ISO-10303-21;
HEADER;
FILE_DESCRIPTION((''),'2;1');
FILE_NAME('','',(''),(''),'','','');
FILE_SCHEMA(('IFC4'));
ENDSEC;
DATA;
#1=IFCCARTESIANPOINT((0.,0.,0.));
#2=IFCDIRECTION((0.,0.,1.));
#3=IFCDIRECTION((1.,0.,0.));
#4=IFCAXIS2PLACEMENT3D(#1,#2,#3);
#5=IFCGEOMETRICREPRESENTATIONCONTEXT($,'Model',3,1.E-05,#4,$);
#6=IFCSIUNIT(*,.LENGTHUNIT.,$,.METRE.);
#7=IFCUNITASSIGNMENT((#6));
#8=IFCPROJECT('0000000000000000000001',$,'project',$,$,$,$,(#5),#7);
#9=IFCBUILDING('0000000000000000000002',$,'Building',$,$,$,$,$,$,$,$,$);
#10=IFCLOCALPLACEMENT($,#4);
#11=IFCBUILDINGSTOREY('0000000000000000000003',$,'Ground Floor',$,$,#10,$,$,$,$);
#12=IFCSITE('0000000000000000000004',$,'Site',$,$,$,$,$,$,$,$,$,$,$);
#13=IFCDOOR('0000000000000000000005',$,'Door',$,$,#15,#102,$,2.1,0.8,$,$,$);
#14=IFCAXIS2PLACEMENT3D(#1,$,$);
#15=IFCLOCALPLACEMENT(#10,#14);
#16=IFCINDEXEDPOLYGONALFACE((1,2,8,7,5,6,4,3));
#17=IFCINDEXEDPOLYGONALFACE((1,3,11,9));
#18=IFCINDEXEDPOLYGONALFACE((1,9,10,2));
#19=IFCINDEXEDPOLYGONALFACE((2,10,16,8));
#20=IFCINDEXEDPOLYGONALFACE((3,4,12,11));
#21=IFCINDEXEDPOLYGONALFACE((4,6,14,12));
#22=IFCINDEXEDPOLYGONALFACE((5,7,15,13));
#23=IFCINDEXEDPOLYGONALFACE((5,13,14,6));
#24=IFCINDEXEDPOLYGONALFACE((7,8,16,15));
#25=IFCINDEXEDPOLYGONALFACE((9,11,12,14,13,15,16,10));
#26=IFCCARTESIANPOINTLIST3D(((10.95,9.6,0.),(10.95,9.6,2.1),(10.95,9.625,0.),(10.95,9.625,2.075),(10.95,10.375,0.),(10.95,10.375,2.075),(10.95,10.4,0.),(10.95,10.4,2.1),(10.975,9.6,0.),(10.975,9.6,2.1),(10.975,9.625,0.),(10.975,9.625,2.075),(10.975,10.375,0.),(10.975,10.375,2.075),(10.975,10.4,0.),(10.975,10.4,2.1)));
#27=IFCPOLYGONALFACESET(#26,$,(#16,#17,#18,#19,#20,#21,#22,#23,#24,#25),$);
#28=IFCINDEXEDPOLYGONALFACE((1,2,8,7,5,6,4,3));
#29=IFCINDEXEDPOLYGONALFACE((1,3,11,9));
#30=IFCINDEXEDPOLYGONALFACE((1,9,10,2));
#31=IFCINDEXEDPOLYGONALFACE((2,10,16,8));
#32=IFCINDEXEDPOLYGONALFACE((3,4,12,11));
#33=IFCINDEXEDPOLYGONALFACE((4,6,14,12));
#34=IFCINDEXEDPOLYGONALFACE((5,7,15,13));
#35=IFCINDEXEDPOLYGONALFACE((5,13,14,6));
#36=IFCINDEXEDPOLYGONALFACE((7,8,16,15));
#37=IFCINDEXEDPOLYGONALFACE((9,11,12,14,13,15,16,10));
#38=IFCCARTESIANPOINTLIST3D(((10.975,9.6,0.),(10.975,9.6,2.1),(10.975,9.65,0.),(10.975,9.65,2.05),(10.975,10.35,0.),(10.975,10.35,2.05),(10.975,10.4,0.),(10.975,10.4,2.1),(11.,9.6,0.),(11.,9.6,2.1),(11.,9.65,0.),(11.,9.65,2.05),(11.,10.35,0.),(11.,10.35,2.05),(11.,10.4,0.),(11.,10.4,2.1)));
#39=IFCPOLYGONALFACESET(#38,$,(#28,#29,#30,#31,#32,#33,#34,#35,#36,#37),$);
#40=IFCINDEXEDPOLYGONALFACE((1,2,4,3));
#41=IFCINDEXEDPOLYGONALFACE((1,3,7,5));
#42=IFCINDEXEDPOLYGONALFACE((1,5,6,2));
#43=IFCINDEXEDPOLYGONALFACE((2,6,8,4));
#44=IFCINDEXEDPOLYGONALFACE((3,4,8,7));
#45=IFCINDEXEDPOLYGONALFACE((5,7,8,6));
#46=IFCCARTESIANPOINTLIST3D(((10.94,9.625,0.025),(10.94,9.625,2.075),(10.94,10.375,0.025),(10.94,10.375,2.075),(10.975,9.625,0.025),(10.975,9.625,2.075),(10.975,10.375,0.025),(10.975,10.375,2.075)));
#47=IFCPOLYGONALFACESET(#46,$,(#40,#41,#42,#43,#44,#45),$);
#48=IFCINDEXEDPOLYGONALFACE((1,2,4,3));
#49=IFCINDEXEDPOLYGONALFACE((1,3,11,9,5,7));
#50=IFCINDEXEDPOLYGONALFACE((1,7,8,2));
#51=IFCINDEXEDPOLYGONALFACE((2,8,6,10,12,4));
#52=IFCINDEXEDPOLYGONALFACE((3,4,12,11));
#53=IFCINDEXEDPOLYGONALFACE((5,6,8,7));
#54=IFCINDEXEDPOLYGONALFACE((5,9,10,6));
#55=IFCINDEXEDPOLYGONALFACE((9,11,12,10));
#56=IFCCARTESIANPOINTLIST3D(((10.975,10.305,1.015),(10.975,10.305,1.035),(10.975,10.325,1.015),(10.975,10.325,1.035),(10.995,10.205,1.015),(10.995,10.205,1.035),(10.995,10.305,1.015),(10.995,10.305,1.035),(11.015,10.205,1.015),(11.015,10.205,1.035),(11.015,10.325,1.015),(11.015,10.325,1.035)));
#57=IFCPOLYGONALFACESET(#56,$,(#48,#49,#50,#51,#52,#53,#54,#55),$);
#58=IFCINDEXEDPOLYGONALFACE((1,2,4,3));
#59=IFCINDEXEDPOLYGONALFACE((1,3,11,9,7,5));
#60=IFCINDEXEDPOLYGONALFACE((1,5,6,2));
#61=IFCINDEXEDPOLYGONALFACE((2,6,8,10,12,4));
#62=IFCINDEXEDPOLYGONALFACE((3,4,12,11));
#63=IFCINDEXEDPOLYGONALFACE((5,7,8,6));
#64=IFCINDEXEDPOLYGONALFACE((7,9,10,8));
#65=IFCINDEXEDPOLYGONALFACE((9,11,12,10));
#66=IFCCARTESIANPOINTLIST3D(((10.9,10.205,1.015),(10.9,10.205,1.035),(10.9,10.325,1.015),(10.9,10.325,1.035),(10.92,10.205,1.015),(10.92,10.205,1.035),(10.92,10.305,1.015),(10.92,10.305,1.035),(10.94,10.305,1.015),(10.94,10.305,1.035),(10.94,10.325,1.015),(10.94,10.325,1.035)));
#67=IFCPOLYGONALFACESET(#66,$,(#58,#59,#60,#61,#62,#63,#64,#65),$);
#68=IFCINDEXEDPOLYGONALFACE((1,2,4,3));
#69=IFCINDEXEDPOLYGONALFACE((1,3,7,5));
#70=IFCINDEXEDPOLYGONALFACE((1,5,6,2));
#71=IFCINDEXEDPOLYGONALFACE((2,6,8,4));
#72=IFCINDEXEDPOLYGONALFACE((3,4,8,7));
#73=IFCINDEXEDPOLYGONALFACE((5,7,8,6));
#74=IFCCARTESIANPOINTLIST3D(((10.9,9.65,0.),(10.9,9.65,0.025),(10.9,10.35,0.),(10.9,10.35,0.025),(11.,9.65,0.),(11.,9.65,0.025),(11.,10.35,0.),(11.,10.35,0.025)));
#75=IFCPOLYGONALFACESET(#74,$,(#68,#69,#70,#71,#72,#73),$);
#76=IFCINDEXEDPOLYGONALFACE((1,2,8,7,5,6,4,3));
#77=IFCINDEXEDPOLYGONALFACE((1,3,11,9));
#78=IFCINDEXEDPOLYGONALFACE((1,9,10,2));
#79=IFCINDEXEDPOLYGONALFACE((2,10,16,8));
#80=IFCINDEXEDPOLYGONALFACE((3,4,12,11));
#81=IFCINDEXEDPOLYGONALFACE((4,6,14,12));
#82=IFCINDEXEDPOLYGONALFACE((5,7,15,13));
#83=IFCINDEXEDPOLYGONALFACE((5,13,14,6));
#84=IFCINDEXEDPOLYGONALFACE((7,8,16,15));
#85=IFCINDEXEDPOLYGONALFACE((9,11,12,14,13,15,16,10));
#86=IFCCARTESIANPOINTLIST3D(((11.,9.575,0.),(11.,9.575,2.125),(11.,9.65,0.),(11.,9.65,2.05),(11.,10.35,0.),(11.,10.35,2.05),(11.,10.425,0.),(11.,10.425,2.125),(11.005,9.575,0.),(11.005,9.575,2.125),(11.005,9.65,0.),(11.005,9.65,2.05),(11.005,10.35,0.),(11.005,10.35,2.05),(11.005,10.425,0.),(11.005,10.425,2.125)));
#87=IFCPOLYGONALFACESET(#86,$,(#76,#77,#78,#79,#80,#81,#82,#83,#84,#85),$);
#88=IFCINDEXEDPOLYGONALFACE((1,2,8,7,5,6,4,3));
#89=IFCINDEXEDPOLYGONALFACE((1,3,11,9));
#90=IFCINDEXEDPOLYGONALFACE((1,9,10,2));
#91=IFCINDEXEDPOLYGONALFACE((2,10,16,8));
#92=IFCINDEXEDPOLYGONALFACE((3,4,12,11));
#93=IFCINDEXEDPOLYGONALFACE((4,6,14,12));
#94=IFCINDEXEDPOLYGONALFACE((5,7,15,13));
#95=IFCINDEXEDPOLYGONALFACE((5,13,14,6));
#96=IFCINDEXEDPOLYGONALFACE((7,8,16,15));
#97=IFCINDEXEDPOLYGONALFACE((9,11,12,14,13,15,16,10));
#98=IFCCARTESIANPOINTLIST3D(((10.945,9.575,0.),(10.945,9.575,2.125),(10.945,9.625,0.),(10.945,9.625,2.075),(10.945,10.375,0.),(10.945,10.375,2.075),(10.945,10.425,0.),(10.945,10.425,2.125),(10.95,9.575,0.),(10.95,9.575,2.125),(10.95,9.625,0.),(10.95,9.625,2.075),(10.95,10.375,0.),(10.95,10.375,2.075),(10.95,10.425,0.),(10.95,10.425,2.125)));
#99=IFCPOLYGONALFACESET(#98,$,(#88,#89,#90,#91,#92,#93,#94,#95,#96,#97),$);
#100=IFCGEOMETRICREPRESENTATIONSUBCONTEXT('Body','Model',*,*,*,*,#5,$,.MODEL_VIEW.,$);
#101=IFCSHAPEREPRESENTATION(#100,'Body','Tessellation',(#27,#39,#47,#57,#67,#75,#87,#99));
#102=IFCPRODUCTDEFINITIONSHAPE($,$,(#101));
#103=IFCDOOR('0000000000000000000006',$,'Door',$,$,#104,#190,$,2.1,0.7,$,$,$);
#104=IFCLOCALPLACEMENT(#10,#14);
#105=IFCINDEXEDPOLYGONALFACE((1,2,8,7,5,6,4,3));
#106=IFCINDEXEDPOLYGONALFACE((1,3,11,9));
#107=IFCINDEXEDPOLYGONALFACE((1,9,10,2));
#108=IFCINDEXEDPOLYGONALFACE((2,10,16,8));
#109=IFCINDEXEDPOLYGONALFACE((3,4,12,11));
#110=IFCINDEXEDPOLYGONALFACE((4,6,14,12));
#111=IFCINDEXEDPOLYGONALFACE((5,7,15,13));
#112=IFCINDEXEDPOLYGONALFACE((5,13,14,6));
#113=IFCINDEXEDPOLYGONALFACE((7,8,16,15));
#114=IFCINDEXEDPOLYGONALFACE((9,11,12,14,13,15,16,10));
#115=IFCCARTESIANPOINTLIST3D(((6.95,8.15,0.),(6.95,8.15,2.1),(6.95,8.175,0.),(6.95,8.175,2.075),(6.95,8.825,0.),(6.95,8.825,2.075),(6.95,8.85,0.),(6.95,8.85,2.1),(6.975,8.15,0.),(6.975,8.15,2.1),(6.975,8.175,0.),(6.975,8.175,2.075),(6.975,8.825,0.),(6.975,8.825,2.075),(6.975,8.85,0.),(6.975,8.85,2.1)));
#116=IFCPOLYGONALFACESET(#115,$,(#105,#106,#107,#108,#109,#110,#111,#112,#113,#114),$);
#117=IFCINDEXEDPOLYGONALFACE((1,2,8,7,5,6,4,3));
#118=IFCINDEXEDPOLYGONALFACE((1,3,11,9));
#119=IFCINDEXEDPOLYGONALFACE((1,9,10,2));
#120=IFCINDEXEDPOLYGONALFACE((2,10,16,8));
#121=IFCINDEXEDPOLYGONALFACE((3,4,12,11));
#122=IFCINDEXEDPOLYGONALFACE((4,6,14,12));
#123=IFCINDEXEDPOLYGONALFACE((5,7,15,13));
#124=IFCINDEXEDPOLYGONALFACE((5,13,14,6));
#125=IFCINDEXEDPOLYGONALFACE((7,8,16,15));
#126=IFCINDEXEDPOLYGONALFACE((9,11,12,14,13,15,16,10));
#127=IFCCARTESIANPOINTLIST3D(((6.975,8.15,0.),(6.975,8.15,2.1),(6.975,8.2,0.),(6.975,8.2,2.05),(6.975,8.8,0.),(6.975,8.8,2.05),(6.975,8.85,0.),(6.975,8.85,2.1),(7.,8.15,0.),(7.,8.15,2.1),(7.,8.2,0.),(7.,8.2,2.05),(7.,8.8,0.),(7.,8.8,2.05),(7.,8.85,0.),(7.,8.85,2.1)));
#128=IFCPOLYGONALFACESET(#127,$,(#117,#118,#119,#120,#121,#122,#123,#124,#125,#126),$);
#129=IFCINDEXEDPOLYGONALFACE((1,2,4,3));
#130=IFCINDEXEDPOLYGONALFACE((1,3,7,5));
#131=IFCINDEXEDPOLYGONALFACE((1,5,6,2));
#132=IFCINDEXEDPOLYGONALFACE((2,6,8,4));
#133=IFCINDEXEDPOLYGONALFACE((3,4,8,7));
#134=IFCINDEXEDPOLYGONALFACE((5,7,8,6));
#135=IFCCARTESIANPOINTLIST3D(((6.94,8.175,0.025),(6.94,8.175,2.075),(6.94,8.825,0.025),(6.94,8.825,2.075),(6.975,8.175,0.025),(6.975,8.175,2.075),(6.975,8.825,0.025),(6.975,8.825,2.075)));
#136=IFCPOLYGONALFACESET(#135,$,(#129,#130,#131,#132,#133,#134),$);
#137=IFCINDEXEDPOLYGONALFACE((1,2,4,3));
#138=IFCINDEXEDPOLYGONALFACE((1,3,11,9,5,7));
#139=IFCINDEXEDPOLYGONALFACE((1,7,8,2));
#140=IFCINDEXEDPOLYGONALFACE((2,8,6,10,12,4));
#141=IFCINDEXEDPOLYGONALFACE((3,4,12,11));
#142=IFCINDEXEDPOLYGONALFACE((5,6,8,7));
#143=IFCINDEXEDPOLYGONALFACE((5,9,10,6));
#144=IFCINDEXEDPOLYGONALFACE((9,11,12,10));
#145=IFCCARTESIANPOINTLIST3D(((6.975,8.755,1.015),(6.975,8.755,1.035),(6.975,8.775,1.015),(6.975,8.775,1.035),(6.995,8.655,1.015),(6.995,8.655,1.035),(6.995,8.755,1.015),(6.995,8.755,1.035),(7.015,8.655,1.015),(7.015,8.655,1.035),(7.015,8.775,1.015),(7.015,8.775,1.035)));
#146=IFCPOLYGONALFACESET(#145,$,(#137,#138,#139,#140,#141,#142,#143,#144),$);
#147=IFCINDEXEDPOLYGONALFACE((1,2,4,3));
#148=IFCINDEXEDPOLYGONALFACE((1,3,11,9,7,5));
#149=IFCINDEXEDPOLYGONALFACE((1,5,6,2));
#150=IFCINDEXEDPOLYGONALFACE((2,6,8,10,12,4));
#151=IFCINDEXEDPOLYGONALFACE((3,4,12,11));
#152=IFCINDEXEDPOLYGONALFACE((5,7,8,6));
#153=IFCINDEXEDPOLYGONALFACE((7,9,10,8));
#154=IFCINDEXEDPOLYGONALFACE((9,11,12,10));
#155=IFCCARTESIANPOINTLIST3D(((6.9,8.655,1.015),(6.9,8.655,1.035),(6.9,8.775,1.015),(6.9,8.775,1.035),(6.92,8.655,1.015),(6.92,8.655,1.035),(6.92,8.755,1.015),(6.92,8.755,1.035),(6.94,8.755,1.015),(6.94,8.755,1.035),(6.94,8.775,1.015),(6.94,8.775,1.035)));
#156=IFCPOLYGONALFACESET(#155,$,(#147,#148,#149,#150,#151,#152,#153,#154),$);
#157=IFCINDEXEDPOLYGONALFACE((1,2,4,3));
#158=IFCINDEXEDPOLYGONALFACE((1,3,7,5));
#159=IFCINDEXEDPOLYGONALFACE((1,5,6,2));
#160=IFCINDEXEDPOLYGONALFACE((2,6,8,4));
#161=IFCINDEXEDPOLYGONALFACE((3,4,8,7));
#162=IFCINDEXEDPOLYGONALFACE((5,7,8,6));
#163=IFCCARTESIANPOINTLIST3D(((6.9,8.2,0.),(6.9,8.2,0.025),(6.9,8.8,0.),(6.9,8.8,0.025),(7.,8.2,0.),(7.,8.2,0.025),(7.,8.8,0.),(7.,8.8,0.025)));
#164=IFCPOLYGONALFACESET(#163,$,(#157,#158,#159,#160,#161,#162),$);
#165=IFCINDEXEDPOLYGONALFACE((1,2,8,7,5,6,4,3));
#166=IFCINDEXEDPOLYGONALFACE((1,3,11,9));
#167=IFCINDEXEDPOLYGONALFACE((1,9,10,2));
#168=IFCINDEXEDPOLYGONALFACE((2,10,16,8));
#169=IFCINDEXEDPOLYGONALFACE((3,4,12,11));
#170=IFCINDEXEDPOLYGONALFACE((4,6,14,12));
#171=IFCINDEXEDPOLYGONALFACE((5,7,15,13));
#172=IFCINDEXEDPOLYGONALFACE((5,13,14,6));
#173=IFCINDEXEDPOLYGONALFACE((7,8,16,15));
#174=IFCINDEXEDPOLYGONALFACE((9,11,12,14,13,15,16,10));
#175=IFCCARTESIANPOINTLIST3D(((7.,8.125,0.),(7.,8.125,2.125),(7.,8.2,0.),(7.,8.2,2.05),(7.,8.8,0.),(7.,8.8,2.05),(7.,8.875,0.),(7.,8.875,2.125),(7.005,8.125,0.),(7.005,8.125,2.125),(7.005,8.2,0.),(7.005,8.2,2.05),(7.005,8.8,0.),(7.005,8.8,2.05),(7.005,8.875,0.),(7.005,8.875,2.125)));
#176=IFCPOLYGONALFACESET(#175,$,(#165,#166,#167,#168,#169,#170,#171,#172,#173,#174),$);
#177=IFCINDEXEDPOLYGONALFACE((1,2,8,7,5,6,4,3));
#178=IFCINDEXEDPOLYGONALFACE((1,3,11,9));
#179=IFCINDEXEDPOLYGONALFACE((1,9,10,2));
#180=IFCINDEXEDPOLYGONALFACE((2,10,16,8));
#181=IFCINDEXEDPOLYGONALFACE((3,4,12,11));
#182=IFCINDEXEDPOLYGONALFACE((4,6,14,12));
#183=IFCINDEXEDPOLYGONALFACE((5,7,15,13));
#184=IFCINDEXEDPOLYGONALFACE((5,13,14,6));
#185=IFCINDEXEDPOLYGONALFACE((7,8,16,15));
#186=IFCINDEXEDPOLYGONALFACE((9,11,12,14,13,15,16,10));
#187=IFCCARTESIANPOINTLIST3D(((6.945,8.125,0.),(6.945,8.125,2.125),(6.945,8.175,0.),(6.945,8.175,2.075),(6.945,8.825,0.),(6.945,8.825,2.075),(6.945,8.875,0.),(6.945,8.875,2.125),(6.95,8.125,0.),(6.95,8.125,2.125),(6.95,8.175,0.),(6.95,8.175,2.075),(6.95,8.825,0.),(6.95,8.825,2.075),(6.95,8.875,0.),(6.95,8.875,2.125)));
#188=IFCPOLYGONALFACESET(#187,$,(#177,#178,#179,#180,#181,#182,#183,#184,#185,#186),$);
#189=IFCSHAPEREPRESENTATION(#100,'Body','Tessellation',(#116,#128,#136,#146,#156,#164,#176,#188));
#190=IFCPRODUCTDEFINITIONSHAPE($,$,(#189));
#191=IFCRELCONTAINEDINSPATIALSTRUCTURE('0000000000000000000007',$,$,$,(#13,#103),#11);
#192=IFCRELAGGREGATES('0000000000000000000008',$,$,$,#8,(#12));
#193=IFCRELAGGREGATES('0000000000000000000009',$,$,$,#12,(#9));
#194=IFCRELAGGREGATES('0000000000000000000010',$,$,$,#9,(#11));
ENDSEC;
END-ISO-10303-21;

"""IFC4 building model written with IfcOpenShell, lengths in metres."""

from ifc_helpers import new_model, si_unit, frame, origin_with_axes, place, context, subcontext, project, spatial, line, indexed_curve, outline, extrude, element, save


model = new_model("IFC4")

# Units and contexts
model_context = context("Model", 3, precision=1e-05, world=origin_with_axes())
body_context = subcontext(model_context, "Body", "Model", "MODEL_VIEW")
ifc_project = project(units=[si_unit("LENGTHUNIT", "METRE")], contexts=[model_context])

# Site, building, storey
site = spatial("IfcSite", under=ifc_project, Name="Site")
building = spatial("IfcBuilding", under=site, Name="Building")
storey_placement = place(None, origin_with_axes())
storey = spatial("IfcBuildingStorey", under=building, at=storey_placement, Name="Ground Floor")

# Doors
door_1_placement = place(storey_placement, frame((11.0, 9.6, 0.0), z_axis=(0.0, 0.0, 1.0), x_axis=(0.0, 1.0, 0.0)))
element("IfcDoor", 1, at=door_1_placement, inside=storey, Name="Door", OverallHeight=2.1, OverallWidth=0.8, context=body_context, shape_type="SweptSolid", body=[
    extrude(outline(indexed_curve([(0.0, 0.0), (0.0, 2.1), (0.8, 2.1), (0.8, 0.0), (0.775, 0.0), (0.775, 2.075), (0.025, 2.075), (0.025, 0.0)], segments=[line(1, 2, 3, 4, 5, 6, 7, 8, 1)])), frame((0.0, 0.025, 0.0), z_axis=(0.0, -1.0, 0.0), x_axis=(1.0, 0.0, 0.0)), (0.0, 0.0, -1.0), 0.025),
    extrude(outline(indexed_curve([(0.0, 0.0), (0.0, 2.1), (0.8, 2.1), (0.8, 0.0), (0.75, 0.0), (0.75, 2.05), (0.05, 2.05), (0.05, 0.0)], segments=[line(1, 2, 3, 4, 5, 6, 7, 8, 1)])), frame((0.0, 0.0, 0.0), z_axis=(0.0, -1.0, 0.0), x_axis=(1.0, 0.0, 0.0)), (0.0, 0.0, -1.0), 0.025),
    extrude(outline(indexed_curve([(0.0, 0.0), (0.75, 0.0), (0.75, 0.035), (0.0, 0.035)], segments=[line(1, 2, 3, 4, 1)])), frame((0.025, 0.025, 0.025), z_axis=(0.0, 0.0, 1.0), x_axis=(1.0, 0.0, 0.0)), (0.0, 0.0, 1.0), 2.05),
    extrude(outline(indexed_curve([(0.0, 0.0), (0.0, -0.04), (-0.12, -0.04), (-0.12, -0.02), (-0.02, -0.02), (-0.02, 0.0)], segments=[line(1, 2, 3, 4, 5, 6, 1)])), frame((0.725, 0.025, 1.015), z_axis=(0.0, 0.0, 1.0), x_axis=(1.0, 0.0, 0.0)), (0.0, 0.0, 1.0), 0.02),
    extrude(outline(indexed_curve([(0.0, 0.0), (0.0, 0.04), (-0.12, 0.04), (-0.12, 0.02), (-0.02, 0.02), (-0.02, 0.0)], segments=[line(1, 2, 3, 4, 5, 6, 1)])), frame((0.725, 0.06, 1.015), z_axis=(0.0, 0.0, 1.0), x_axis=(1.0, 0.0, 0.0)), (0.0, 0.0, 1.0), 0.02),
    extrude(outline(indexed_curve([(0.0, 0.0), (0.7, 0.0), (0.7, 0.1), (0.0, 0.1)], segments=[line(1, 2, 3, 4, 1)])), frame((0.05, 0.0, 0.0), z_axis=(0.0, 0.0, 1.0), x_axis=(1.0, 0.0, 0.0)), (0.0, 0.0, 1.0), 0.025),
    extrude(outline(indexed_curve([(0.0, 0.0), (0.0, 2.125), (0.85, 2.125), (0.85, 0.0), (0.775, 0.0), (0.775, 2.05), (0.075, 2.05), (0.075, 0.0)], segments=[line(1, 2, 3, 4, 5, 6, 7, 8, 1)])), frame((-0.025, -0.005, 0.0), z_axis=(0.0, -1.0, 0.0), x_axis=(1.0, 0.0, 0.0)), (0.0, 0.0, -1.0), 0.005),
    extrude(outline(indexed_curve([(0.0, 0.0), (0.0, 2.125), (0.85, 2.125), (0.85, 0.0), (0.8, 0.0), (0.8, 2.075), (0.05, 2.075), (0.05, 0.0)], segments=[line(1, 2, 3, 4, 5, 6, 7, 8, 1)])), frame((-0.025, 0.05, 0.0), z_axis=(0.0, -1.0, 0.0), x_axis=(1.0, 0.0, 0.0)), (0.0, 0.0, -1.0), 0.005),
])
door_2_placement = place(storey_placement, frame((7.0, 8.15, 0.0), z_axis=(0.0, 0.0, 1.0), x_axis=(0.0, 1.0, 0.0)))
element("IfcDoor", 2, at=door_2_placement, inside=storey, Name="Door", OverallHeight=2.1, OverallWidth=0.7, context=body_context, shape_type="SweptSolid", body=[
    extrude(outline(indexed_curve([(0.0, 0.0), (0.0, 2.1), (0.7, 2.1), (0.7, 0.0), (0.675, 0.0), (0.675, 2.075), (0.025, 2.075), (0.025, 0.0)], segments=[line(1, 2, 3, 4, 5, 6, 7, 8, 1)])), frame((0.0, 0.025, 0.0), z_axis=(0.0, -1.0, 0.0), x_axis=(1.0, 0.0, 0.0)), (0.0, 0.0, -1.0), 0.025),
    extrude(outline(indexed_curve([(0.0, 0.0), (0.0, 2.1), (0.7, 2.1), (0.7, 0.0), (0.65, 0.0), (0.65, 2.05), (0.05, 2.05), (0.05, 0.0)], segments=[line(1, 2, 3, 4, 5, 6, 7, 8, 1)])), frame((0.0, 0.0, 0.0), z_axis=(0.0, -1.0, 0.0), x_axis=(1.0, 0.0, 0.0)), (0.0, 0.0, -1.0), 0.025),
    extrude(outline(indexed_curve([(0.0, 0.0), (0.65, 0.0), (0.65, 0.035), (0.0, 0.035)], segments=[line(1, 2, 3, 4, 1)])), frame((0.025, 0.025, 0.025), z_axis=(0.0, 0.0, 1.0), x_axis=(1.0, 0.0, 0.0)), (0.0, 0.0, 1.0), 2.05),
    extrude(outline(indexed_curve([(0.0, 0.0), (0.0, -0.04), (-0.12, -0.04), (-0.12, -0.02), (-0.02, -0.02), (-0.02, 0.0)], segments=[line(1, 2, 3, 4, 5, 6, 1)])), frame((0.625, 0.025, 1.015), z_axis=(0.0, 0.0, 1.0), x_axis=(1.0, 0.0, 0.0)), (0.0, 0.0, 1.0), 0.02),
    extrude(outline(indexed_curve([(0.0, 0.0), (0.0, 0.04), (-0.12, 0.04), (-0.12, 0.02), (-0.02, 0.02), (-0.02, 0.0)], segments=[line(1, 2, 3, 4, 5, 6, 1)])), frame((0.625, 0.06, 1.015), z_axis=(0.0, 0.0, 1.0), x_axis=(1.0, 0.0, 0.0)), (0.0, 0.0, 1.0), 0.02),
    extrude(outline(indexed_curve([(0.0, 0.0), (0.6, 0.0), (0.6, 0.1), (0.0, 0.1)], segments=[line(1, 2, 3, 4, 1)])), frame((0.05, 0.0, 0.0), z_axis=(0.0, 0.0, 1.0), x_axis=(1.0, 0.0, 0.0)), (0.0, 0.0, 1.0), 0.025),
    extrude(outline(indexed_curve([(0.0, 0.0), (0.0, 2.125), (0.75, 2.125), (0.75, 0.0), (0.675, 0.0), (0.675, 2.05), (0.075, 2.05), (0.075, 0.0)], segments=[line(1, 2, 3, 4, 5, 6, 7, 8, 1)])), frame((-0.025, -0.005, 0.0), z_axis=(0.0, -1.0, 0.0), x_axis=(1.0, 0.0, 0.0)), (0.0, 0.0, -1.0), 0.005),
    extrude(outline(indexed_curve([(0.0, 0.0), (0.0, 2.125), (0.75, 2.125), (0.75, 0.0), (0.7, 0.0), (0.7, 2.075), (0.05, 2.075), (0.05, 0.0)], segments=[line(1, 2, 3, 4, 5, 6, 7, 8, 1)])), frame((-0.025, 0.05, 0.0), z_axis=(0.0, -1.0, 0.0), x_axis=(1.0, 0.0, 0.0)), (0.0, 0.0, -1.0), 0.005),
])

save(model, "model.ifc")
